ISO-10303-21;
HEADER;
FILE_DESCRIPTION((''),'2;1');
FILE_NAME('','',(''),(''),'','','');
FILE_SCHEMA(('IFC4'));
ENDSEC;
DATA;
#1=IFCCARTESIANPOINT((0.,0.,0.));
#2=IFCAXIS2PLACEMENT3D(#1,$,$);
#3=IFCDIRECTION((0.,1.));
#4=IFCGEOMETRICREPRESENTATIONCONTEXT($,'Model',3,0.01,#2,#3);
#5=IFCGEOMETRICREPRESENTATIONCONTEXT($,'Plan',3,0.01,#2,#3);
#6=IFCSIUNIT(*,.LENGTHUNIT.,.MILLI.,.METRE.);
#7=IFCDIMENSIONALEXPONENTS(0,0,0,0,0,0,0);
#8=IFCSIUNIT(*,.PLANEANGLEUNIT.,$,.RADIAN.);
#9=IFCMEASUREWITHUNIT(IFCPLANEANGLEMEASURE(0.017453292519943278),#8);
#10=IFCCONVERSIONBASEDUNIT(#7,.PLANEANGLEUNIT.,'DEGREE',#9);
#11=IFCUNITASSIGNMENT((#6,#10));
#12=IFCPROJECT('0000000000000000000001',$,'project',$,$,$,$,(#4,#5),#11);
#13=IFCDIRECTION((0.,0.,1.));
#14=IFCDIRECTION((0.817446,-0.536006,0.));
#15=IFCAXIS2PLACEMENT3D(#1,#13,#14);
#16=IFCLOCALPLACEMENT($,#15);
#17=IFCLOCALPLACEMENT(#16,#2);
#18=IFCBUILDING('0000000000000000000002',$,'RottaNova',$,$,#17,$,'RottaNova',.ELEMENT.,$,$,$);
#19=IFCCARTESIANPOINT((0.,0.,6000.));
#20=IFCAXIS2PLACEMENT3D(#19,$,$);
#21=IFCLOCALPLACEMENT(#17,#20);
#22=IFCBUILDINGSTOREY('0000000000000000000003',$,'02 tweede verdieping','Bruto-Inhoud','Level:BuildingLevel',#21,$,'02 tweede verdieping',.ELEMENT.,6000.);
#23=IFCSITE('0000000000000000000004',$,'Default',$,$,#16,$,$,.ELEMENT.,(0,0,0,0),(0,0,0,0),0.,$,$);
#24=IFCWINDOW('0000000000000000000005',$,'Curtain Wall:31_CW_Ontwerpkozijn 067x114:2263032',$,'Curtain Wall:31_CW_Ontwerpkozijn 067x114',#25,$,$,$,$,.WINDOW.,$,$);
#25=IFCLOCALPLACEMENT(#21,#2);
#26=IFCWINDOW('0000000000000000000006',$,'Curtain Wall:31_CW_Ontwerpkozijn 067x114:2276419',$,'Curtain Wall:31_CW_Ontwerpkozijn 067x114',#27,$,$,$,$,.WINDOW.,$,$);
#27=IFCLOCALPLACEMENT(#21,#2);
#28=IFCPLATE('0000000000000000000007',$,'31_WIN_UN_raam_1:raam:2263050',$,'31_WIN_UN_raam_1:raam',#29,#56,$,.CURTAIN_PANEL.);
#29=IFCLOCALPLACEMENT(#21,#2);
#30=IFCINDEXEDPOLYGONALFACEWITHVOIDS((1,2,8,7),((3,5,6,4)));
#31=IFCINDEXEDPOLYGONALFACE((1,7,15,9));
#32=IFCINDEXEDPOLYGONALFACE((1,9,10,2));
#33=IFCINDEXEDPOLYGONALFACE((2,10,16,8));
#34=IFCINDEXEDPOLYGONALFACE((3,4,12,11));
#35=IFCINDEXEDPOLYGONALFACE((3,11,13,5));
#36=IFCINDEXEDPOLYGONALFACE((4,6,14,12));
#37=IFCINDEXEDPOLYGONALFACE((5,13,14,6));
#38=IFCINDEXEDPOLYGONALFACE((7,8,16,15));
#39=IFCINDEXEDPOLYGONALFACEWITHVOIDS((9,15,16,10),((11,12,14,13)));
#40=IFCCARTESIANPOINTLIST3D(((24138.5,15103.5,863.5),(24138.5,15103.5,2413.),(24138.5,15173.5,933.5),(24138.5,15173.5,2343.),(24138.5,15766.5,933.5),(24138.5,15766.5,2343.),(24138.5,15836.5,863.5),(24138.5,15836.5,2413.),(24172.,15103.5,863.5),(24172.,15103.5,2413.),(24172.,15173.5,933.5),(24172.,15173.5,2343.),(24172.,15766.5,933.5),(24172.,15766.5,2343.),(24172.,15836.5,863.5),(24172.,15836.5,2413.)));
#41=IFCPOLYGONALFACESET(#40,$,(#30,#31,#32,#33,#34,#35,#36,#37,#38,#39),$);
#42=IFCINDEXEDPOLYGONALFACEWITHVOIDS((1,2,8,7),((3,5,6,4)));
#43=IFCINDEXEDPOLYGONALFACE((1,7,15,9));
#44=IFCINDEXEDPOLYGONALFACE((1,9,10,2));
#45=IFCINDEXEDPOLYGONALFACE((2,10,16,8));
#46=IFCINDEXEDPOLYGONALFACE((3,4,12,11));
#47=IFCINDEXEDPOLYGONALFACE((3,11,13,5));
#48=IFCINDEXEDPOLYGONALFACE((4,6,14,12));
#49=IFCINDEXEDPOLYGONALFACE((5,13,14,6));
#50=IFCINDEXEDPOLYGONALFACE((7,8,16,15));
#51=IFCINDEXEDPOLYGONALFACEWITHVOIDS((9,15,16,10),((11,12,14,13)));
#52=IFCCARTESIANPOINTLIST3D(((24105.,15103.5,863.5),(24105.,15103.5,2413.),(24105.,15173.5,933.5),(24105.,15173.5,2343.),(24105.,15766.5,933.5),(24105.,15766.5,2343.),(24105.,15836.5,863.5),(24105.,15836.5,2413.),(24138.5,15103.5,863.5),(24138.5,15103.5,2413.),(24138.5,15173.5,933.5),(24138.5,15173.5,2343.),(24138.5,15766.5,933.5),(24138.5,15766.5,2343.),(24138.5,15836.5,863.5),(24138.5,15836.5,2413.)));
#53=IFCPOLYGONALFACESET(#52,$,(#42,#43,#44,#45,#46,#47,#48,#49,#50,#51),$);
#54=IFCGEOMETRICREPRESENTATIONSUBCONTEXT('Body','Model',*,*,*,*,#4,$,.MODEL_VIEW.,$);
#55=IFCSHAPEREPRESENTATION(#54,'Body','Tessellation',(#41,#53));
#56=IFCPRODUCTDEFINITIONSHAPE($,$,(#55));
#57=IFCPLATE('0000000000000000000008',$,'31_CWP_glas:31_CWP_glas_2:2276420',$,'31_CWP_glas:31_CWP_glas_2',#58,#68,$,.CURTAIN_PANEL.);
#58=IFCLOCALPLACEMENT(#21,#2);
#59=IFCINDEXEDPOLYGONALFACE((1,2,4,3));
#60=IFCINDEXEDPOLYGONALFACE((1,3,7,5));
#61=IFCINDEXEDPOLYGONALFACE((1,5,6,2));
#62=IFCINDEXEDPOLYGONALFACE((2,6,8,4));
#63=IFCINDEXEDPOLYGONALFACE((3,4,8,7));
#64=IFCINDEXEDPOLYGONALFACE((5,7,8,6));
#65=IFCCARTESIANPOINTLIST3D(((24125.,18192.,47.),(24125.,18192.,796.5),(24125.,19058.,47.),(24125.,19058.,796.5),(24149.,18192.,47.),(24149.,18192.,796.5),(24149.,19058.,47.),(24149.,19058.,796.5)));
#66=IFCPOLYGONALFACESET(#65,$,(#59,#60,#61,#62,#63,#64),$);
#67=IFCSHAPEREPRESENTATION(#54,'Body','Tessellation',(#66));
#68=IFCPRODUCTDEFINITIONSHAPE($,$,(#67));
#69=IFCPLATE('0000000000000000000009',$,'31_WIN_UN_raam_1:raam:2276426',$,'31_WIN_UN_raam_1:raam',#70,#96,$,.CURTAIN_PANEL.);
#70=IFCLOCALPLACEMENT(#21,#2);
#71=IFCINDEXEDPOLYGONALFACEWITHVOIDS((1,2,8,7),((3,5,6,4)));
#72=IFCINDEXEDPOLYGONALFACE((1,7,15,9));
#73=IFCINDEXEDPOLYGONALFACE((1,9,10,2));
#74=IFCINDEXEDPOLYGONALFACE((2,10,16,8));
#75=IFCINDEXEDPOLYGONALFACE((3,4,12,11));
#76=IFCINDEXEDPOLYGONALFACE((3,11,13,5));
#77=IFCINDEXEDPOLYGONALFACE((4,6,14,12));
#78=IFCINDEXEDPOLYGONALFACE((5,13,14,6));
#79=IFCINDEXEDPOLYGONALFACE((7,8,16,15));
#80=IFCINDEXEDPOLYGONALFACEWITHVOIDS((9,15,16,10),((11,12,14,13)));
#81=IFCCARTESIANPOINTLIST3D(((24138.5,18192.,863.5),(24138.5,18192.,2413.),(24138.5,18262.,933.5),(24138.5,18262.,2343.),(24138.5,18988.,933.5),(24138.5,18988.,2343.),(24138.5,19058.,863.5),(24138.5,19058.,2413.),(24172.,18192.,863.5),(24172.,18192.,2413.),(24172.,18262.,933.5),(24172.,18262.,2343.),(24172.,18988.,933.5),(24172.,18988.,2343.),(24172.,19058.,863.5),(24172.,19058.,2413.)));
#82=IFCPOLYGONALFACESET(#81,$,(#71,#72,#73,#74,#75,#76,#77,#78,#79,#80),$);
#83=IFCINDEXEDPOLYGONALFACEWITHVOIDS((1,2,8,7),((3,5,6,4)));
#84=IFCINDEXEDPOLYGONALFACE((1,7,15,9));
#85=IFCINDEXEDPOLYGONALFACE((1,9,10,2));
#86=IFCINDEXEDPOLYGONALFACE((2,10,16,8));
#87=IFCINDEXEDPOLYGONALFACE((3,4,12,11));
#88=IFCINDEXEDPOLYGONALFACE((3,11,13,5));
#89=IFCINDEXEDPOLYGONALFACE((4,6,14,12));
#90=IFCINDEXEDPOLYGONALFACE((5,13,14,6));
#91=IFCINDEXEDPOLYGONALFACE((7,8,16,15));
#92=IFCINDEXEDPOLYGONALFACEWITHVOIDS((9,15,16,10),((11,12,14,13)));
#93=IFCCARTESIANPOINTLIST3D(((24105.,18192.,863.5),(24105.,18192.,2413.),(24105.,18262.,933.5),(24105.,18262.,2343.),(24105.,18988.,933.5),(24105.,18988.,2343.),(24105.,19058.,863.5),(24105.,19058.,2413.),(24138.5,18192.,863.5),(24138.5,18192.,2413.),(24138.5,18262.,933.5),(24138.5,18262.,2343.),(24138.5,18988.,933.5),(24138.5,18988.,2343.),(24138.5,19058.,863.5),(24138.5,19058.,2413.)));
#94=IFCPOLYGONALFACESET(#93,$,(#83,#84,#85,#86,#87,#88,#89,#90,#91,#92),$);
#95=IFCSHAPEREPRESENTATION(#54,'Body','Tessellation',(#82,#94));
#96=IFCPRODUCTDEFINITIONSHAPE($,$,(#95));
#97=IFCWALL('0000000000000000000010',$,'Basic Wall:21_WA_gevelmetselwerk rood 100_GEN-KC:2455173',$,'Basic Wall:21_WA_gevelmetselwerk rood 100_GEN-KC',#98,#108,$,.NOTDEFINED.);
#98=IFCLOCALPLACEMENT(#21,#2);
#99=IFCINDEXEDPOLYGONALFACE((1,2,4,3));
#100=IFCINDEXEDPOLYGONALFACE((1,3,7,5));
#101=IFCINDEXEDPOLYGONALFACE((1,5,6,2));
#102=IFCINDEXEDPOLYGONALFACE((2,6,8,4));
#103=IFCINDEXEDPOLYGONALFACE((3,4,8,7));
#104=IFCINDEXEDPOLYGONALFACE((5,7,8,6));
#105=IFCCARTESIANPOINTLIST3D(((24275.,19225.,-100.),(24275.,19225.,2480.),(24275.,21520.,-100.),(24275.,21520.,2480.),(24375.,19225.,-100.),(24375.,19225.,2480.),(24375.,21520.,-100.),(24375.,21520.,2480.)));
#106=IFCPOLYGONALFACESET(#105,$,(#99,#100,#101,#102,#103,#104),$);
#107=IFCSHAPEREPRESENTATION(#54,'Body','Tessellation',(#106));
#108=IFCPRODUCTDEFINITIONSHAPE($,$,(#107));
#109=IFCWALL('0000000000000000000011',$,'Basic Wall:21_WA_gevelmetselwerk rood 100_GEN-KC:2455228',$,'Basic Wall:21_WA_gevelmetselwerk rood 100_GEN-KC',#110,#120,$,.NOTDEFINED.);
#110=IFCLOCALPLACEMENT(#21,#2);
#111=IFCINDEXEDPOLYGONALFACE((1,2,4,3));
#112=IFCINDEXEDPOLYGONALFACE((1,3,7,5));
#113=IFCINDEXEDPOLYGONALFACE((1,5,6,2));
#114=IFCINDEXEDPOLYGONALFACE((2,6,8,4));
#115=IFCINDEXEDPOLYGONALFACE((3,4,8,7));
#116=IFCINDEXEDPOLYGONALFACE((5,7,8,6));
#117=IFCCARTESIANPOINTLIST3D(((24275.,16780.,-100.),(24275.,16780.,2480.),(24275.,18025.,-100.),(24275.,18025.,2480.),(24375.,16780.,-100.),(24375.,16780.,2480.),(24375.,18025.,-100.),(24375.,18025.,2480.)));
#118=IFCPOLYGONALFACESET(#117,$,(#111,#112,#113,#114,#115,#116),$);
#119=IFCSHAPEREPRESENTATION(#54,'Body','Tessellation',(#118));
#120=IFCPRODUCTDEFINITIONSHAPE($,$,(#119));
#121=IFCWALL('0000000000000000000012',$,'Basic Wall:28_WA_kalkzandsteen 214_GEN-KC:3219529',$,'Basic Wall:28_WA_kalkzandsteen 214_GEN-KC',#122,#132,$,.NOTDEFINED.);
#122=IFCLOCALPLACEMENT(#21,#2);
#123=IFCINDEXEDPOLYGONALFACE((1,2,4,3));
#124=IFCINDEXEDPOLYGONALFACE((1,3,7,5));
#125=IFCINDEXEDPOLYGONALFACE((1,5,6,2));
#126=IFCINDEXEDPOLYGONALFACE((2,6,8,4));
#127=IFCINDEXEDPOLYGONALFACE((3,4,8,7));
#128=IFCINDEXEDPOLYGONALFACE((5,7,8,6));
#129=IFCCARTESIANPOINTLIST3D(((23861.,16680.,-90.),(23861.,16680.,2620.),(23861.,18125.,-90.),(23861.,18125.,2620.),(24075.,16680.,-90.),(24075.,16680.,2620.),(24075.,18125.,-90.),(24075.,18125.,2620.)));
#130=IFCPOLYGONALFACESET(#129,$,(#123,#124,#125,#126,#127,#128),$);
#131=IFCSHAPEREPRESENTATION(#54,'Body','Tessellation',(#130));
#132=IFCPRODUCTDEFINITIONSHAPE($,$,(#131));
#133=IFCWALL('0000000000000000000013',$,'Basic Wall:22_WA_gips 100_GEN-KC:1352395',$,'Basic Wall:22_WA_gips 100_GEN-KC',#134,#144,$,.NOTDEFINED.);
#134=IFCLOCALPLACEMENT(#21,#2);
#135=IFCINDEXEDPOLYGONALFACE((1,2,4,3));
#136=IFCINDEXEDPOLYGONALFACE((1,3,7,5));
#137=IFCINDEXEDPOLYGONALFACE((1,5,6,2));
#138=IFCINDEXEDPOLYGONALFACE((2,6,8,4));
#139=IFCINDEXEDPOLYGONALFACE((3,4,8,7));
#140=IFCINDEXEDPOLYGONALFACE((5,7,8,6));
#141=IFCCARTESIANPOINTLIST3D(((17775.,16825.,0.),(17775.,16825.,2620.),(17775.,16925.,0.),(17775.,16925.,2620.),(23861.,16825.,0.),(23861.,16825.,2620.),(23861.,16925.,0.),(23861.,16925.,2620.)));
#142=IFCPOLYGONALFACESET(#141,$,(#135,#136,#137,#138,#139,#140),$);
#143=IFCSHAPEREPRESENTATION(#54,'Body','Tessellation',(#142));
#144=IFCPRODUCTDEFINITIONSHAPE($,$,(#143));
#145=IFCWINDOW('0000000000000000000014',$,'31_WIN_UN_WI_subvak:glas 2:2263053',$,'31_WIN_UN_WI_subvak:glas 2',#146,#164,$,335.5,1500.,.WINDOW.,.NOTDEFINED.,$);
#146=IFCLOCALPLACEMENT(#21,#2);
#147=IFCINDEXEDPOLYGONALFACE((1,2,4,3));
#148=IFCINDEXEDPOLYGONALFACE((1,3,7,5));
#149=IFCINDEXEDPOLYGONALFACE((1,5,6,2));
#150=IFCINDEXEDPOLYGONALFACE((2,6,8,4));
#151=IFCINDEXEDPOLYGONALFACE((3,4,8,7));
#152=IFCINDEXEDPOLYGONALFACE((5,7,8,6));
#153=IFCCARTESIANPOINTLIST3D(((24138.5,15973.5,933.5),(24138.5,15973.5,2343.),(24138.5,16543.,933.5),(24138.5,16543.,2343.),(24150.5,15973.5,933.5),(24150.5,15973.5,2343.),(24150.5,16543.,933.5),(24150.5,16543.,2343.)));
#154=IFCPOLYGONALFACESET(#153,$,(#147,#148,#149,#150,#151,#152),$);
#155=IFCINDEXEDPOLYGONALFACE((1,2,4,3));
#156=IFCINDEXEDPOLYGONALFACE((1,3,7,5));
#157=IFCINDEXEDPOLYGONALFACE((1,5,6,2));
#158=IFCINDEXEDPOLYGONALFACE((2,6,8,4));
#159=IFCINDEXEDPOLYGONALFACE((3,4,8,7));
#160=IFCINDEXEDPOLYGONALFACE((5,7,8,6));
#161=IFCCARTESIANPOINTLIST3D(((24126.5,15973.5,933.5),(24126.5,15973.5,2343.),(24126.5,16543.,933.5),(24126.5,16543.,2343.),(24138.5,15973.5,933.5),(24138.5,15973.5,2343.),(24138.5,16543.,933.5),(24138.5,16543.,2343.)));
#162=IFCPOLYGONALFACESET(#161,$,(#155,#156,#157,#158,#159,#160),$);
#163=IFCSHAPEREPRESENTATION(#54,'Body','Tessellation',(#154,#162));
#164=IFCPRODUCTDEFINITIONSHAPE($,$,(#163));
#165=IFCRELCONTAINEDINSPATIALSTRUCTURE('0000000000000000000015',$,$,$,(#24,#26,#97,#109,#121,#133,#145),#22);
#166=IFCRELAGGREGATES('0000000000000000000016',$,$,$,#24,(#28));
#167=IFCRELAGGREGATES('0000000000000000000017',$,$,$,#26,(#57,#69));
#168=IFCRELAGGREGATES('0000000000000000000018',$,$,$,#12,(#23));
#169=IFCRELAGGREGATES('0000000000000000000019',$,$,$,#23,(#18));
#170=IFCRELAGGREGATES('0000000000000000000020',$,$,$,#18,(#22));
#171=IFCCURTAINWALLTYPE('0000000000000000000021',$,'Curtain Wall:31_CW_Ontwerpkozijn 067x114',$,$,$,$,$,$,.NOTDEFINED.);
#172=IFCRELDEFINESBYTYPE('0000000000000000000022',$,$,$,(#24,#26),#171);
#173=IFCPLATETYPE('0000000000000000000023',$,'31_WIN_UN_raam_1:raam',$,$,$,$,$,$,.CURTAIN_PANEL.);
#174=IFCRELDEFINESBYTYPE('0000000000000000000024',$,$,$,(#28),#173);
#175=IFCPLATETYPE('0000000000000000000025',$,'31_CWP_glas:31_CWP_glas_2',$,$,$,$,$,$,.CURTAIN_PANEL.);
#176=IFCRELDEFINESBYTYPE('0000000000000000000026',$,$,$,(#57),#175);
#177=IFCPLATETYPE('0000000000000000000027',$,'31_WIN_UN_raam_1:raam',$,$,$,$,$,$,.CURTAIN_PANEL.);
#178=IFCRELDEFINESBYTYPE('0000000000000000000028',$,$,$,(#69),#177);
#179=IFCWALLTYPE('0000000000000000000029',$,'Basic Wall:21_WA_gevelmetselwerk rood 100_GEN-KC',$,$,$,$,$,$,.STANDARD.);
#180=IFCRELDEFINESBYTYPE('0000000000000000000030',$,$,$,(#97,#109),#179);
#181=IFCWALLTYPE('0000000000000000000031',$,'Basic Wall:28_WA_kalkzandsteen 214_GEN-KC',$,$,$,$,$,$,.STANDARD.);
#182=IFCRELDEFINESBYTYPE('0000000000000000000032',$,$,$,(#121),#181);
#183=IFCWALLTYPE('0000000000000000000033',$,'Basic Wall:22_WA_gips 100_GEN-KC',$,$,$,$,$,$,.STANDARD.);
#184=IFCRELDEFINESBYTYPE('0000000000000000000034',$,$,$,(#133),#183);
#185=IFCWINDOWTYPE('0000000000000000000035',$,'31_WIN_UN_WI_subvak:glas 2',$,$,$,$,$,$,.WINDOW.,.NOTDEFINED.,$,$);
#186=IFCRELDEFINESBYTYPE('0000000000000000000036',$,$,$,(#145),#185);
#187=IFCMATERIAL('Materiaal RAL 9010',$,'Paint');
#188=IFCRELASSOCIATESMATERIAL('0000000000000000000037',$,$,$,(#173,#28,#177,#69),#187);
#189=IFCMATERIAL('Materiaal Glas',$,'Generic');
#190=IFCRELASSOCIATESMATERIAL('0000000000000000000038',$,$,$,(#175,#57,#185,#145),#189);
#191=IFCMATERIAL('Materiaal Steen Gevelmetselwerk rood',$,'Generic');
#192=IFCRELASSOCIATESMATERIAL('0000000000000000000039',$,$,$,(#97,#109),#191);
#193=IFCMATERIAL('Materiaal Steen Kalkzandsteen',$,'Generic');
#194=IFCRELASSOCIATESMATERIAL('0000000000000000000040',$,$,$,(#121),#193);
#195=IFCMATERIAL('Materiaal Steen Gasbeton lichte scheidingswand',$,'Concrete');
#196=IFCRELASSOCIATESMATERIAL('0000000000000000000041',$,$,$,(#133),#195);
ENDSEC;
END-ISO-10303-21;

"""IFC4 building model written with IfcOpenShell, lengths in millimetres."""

from ifc_helpers import new_model, entity, si_unit, converted_unit, direction, frame, origin, place, context, subcontext, project, spatial, indexed_curve, outline, extrude, source, transform, mapped, material, type_object, type_shapes, element, aggregate, save


model = new_model("IFC4")

# Units and contexts
model_context = context("Model", 3, precision=0.01, world=origin(), true_north=direction((0.0, 1.0)))
plan_context = context("Plan", 3, precision=0.01, world=origin(), true_north=direction((0.0, 1.0)))
body_context = subcontext(model_context, "Body", "Model", "MODEL_VIEW")
ifc_project = project(units=[si_unit("LENGTHUNIT", "METRE", prefix="MILLI"), converted_unit("PLANEANGLEUNIT", "DEGREE", entity("IfcPlaneAngleMeasure", 0.017453292519943278), si_unit("PLANEANGLEUNIT", "RADIAN"), dimensions=[0, 0, 0, 0, 0, 0, 0])], contexts=[model_context, plan_context])

# Site, building, storey
site_placement = place(None, frame((0.0, 0.0, 0.0), z_axis=(0.0, 0.0, 1.0), x_axis=(0.817446, -0.536006, 0.0)))
site = spatial("IfcSite", under=ifc_project, at=site_placement, Name="Default", CompositionType="ELEMENT", RefLatitude=(0, 0, 0, 0), RefLongitude=(0, 0, 0, 0), RefElevation=0.0)
building_placement = place(site_placement, origin())
building = spatial("IfcBuilding", under=site, at=building_placement, Name="RottaNova", LongName="RottaNova", CompositionType="ELEMENT")
storey_placement = place(building_placement, frame((0.0, 0.0, 6000.0)))
storey = spatial("IfcBuildingStorey", under=building, at=storey_placement, Name="02 tweede verdieping", Description="Bruto-Inhoud", ObjectType="Level:BuildingLevel", LongName="02 tweede verdieping", CompositionType="ELEMENT", Elevation=6000.0)

# Windows
curtain_wall_type = type_object("IfcCurtainWallType", Name="Curtain Wall:31_CW_Ontwerpkozijn 067x114", PredefinedType="NOTDEFINED")
window_1_placement = place(storey_placement, frame((0.0, 0.0, -6000.0)))
window_1 = element("IfcWindow", 1, at=window_1_placement, inside=storey, type_object=curtain_wall_type, Name="Curtain Wall:31_CW_Ontwerpkozijn 067x114:2263032", ObjectType="Curtain Wall:31_CW_Ontwerpkozijn 067x114", PredefinedType="WINDOW")
window_2_placement = place(storey_placement, frame((0.0, 0.0, -6000.0)))
window_2 = element("IfcWindow", 2, at=window_2_placement, inside=storey, type_object=curtain_wall_type, Name="Curtain Wall:31_CW_Ontwerpkozijn 067x114:2276419", ObjectType="Curtain Wall:31_CW_Ontwerpkozijn 067x114", PredefinedType="WINDOW")

# Plates
ifc_material_1 = material(Name="Materiaal Glas", Category="Generic")
ifc_material_2 = material(Name="Materiaal RAL 9010", Category="Paint")
plate_type_1 = type_object("IfcPlateType", Name="31_WIN_UN_raam_1:raam", PredefinedType="CURTAIN_PANEL", material=ifc_material_2)
shared_shape_1 = source(origin(), body_context, "Body", "SweptSolid", [
    extrude(outline(indexed_curve([(-366.5, -774.8), (366.5, -774.8), (366.5, 774.8), (-366.5, 774.8), (-366.5, -774.8)], self_intersect=False), holes=[indexed_curve([(-296.5, 704.8), (296.5, 704.8), (296.5, -704.8), (-296.5, -704.8), (-296.5, 704.8)], self_intersect=False)]), frame((0.0, 58.5, 774.8), z_axis=(0.0, 1.0, 0.0), x_axis=(1.0, 0.0, 0.0)), (0.0, 0.0, 1.0), 33.5),
    extrude(outline(indexed_curve([(-366.5, -774.8), (366.5, -774.8), (366.5, 774.8), (-366.5, 774.8), (-366.5, -774.8)], self_intersect=False), holes=[indexed_curve([(-296.5, 704.7), (296.5, 704.7), (296.5, -704.8), (-296.5, -704.8), (-296.5, 704.7)], self_intersect=False)]), frame((0.0, 25.0, 774.8), z_axis=(0.0, 1.0, 0.0), x_axis=(1.0, 0.0, 0.0)), (0.0, 0.0, 1.0), 33.5),
])
type_shapes(plate_type_1, [shared_shape_1])
plate_1_placement = place(window_1_placement, frame((24080.0, 15470.0, 6863.5), z_axis=(0.0, 0.0, 1.0), x_axis=(0.0, -1.0, 0.0)))
plate_1 = element("IfcPlate", 3, at=plate_1_placement, type_object=plate_type_1, material=ifc_material_2, Name="31_WIN_UN_raam_1:raam:2263050", ObjectType="31_WIN_UN_raam_1:raam", PredefinedType="CURTAIN_PANEL", context=body_context, shape_type="MappedRepresentation", body=[
    mapped(shared_shape_1, transform((0.0, 0.0, 0.0), scale=1.0)),
])
aggregate(window_1, [plate_1])
plate_type_2 = type_object("IfcPlateType", Name="31_CWP_glas:31_CWP_glas_2", PredefinedType="CURTAIN_PANEL", material=ifc_material_1)
shared_shape_2 = source(origin(), body_context, "Body", "SweptSolid", [
    extrude(outline(indexed_curve([(-12.0, -433.0), (12.0, -433.0), (12.0, 433.0), (-12.0, 433.0), (-12.0, -433.0)], self_intersect=False)), frame((0.0, -57.0, 0.0), z_axis=(0.0, 0.0, 1.0), x_axis=(0.0, 1.0, 0.0)), (0.0, 0.0, 1.0), 749.5),
])
type_shapes(plate_type_2, [shared_shape_2])
plate_2_placement = place(window_2_placement, frame((24080.0, 18625.0, 6047.0), z_axis=(0.0, 0.0, 1.0), x_axis=(0.0, 1.0, 0.0)))
plate_2 = element("IfcPlate", 4, at=plate_2_placement, type_object=plate_type_2, material=ifc_material_1, Name="31_CWP_glas:31_CWP_glas_2:2276420", ObjectType="31_CWP_glas:31_CWP_glas_2", PredefinedType="CURTAIN_PANEL", context=body_context, shape_type="MappedRepresentation", body=[
    mapped(shared_shape_2, transform((0.0, 0.0, 0.0), scale=1.0)),
])
plate_type_3 = type_object("IfcPlateType", Name="31_WIN_UN_raam_1:raam", PredefinedType="CURTAIN_PANEL", material=ifc_material_2)
shared_shape_3 = source(origin(), body_context, "Body", "SweptSolid", [
    extrude(outline(indexed_curve([(-433.0, -774.7), (433.0, -774.7), (433.0, 774.7), (-433.0, 774.7), (-433.0, -774.7)], self_intersect=False), holes=[indexed_curve([(-363.0, 704.7), (363.0, 704.7), (363.0, -704.8), (-363.0, -704.8), (-363.0, 704.7)], self_intersect=False)]), frame((0.0, -92.0, 774.8), z_axis=(0.0, 1.0, 0.0), x_axis=(1.0, 0.0, 0.0)), (0.0, 0.0, 1.0), 33.5),
    extrude(outline(indexed_curve([(-433.0, -774.7), (433.0, -774.7), (433.0, 774.7), (-433.0, 774.7), (-433.0, -774.7)], self_intersect=False), holes=[indexed_curve([(-363.0, 704.7), (363.0, 704.7), (363.0, -704.8), (-363.0, -704.8), (-363.0, 704.7)], self_intersect=False)]), frame((0.0, -58.5, 774.8), z_axis=(0.0, 1.0, 0.0), x_axis=(1.0, 0.0, 0.0)), (0.0, 0.0, 1.0), 33.5),
])
type_shapes(plate_type_3, [shared_shape_3])
plate_3_placement = place(window_2_placement, frame((24080.0, 18625.0, 6863.5), z_axis=(0.0, 0.0, 1.0), x_axis=(0.0, 1.0, 0.0)))
plate_3 = element("IfcPlate", 5, at=plate_3_placement, type_object=plate_type_3, material=ifc_material_2, Name="31_WIN_UN_raam_1:raam:2276426", ObjectType="31_WIN_UN_raam_1:raam", PredefinedType="CURTAIN_PANEL", context=body_context, shape_type="MappedRepresentation", body=[
    mapped(shared_shape_3, transform((0.0, 0.0, 0.0), scale=1.0)),
])
aggregate(window_2, [plate_2, plate_3])

# Walls
ifc_material_3 = material(Name="Materiaal Steen Gevelmetselwerk rood", Category="Generic")
wall_type_1 = type_object("IfcWallType", Name="Basic Wall:21_WA_gevelmetselwerk rood 100_GEN-KC", PredefinedType="STANDARD")
wall_1_placement = place(storey_placement, frame((24325.0, 19225.0, -100.0), z_axis=(0.0, 0.0, 1.0), x_axis=(0.0, 1.0, 0.0)))
element("IfcWall", 6, at=wall_1_placement, inside=storey, type_object=wall_type_1, material=ifc_material_3, Name="Basic Wall:21_WA_gevelmetselwerk rood 100_GEN-KC:2455173", ObjectType="Basic Wall:21_WA_gevelmetselwerk rood 100_GEN-KC", PredefinedType="NOTDEFINED", context=body_context, shape_type="SweptSolid", body=[
    extrude(outline(indexed_curve([(2295.0, 50.0), (0.0, 50.0), (0.0, -50.0), (2295.0, -50.0), (2295.0, 50.0)], self_intersect=False)), origin(), (0.0, 0.0, 1.0), 2580.0),
])
wall_2_placement = place(storey_placement, frame((24325.0, 16780.0, -100.0), z_axis=(0.0, 0.0, 1.0), x_axis=(0.0, 1.0, 0.0)))
element("IfcWall", 7, at=wall_2_placement, inside=storey, type_object=wall_type_1, material=ifc_material_3, Name="Basic Wall:21_WA_gevelmetselwerk rood 100_GEN-KC:2455228", ObjectType="Basic Wall:21_WA_gevelmetselwerk rood 100_GEN-KC", PredefinedType="NOTDEFINED", context=body_context, shape_type="SweptSolid", body=[
    extrude(outline(indexed_curve([(1245.0, 50.0), (0.0, 50.0), (0.0, -50.0), (1245.0, -50.0), (1245.0, 50.0)], self_intersect=False)), origin(), (0.0, 0.0, 1.0), 2580.0),
])
ifc_material_4 = material(Name="Materiaal Steen Kalkzandsteen", Category="Generic")
wall_type_2 = type_object("IfcWallType", Name="Basic Wall:28_WA_kalkzandsteen 214_GEN-KC", PredefinedType="STANDARD")
wall_3_placement = place(storey_placement, frame((23968.0, 18125.0, -90.0), z_axis=(0.0, 0.0, 1.0), x_axis=(0.0, -1.0, 0.0)))
element("IfcWall", 8, at=wall_3_placement, inside=storey, type_object=wall_type_2, material=ifc_material_4, Name="Basic Wall:28_WA_kalkzandsteen 214_GEN-KC:3219529", ObjectType="Basic Wall:28_WA_kalkzandsteen 214_GEN-KC", PredefinedType="NOTDEFINED", context=body_context, shape_type="SweptSolid", body=[
    extrude(outline(indexed_curve([(1445.0, 107.0), (0.0, 107.0), (0.0, -107.0), (1445.0, -107.0), (1445.0, 107.0)], self_intersect=False)), origin(), (0.0, 0.0, 1.0), 2710.0),
])
ifc_material_5 = material(Name="Materiaal Steen Gasbeton lichte scheidingswand", Category="Concrete")
wall_type_3 = type_object("IfcWallType", Name="Basic Wall:22_WA_gips 100_GEN-KC", PredefinedType="STANDARD")
wall_4_placement = place(storey_placement, frame((23861.0, 16875.0, 0.0), z_axis=(0.0, 0.0, 1.0), x_axis=(-1.0, 0.0, 0.0)))
element("IfcWall", 9, at=wall_4_placement, inside=storey, type_object=wall_type_3, material=ifc_material_5, Name="Basic Wall:22_WA_gips 100_GEN-KC:1352395", ObjectType="Basic Wall:22_WA_gips 100_GEN-KC", PredefinedType="NOTDEFINED", context=body_context, shape_type="SweptSolid", body=[
    extrude(outline(indexed_curve([(6086.0, 50.0), (0.0, 50.0), (0.0, -50.0), (6086.0, -50.0), (6086.0, 50.0)], self_intersect=False)), origin(), (0.0, 0.0, 1.0), 2620.0),
])

# Window
window_type_1 = type_object("IfcWindowType", Name="31_WIN_UN_WI_subvak:glas 2", PartitioningType="NOTDEFINED", PredefinedType="WINDOW", material=ifc_material_1)
shared_shape_4 = source(origin(), body_context, "Body", "SweptSolid", [
    extrude(outline(indexed_curve([(-6.0, -284.7), (6.0, -284.7), (6.0, 284.7), (-6.0, 284.7), (-6.0, -284.7)], self_intersect=False)), frame((0.0, 6.0, 0.0), z_axis=(0.0, 0.0, 1.0), x_axis=(0.0, -1.0, 0.0)), (0.0, 0.0, 1.0), 1409.5),
    extrude(outline(indexed_curve([(-6.0, -284.8), (6.0, -284.8), (6.0, 284.8), (-6.0, 284.8), (-6.0, -284.8)], self_intersect=False)), frame((0.0, -6.0, 0.0), z_axis=(0.0, 0.0, 1.0), x_axis=(0.0, -1.0, 0.0)), (0.0, 0.0, 1.0), 1409.5),
])
type_shapes(window_type_1, [shared_shape_4])
window_3_placement = place(storey_placement, frame((24138.5, 16258.3, 933.5), z_axis=(0.0, 0.0, 1.0), x_axis=(0.0, -1.0, 0.0)))
element("IfcWindow", 10, at=window_3_placement, inside=storey, type_object=window_type_1, material=ifc_material_1, Name="31_WIN_UN_WI_subvak:glas 2:2263053", ObjectType="31_WIN_UN_WI_subvak:glas 2", OverallHeight=335.5, OverallWidth=1500.0, PartitioningType="NOTDEFINED", PredefinedType="WINDOW", context=body_context, shape_type="MappedRepresentation", body=[
    mapped(shared_shape_4, transform((0.0, 0.0, 0.0), scale=1.0)),
])

save(model, "model.ifc")
